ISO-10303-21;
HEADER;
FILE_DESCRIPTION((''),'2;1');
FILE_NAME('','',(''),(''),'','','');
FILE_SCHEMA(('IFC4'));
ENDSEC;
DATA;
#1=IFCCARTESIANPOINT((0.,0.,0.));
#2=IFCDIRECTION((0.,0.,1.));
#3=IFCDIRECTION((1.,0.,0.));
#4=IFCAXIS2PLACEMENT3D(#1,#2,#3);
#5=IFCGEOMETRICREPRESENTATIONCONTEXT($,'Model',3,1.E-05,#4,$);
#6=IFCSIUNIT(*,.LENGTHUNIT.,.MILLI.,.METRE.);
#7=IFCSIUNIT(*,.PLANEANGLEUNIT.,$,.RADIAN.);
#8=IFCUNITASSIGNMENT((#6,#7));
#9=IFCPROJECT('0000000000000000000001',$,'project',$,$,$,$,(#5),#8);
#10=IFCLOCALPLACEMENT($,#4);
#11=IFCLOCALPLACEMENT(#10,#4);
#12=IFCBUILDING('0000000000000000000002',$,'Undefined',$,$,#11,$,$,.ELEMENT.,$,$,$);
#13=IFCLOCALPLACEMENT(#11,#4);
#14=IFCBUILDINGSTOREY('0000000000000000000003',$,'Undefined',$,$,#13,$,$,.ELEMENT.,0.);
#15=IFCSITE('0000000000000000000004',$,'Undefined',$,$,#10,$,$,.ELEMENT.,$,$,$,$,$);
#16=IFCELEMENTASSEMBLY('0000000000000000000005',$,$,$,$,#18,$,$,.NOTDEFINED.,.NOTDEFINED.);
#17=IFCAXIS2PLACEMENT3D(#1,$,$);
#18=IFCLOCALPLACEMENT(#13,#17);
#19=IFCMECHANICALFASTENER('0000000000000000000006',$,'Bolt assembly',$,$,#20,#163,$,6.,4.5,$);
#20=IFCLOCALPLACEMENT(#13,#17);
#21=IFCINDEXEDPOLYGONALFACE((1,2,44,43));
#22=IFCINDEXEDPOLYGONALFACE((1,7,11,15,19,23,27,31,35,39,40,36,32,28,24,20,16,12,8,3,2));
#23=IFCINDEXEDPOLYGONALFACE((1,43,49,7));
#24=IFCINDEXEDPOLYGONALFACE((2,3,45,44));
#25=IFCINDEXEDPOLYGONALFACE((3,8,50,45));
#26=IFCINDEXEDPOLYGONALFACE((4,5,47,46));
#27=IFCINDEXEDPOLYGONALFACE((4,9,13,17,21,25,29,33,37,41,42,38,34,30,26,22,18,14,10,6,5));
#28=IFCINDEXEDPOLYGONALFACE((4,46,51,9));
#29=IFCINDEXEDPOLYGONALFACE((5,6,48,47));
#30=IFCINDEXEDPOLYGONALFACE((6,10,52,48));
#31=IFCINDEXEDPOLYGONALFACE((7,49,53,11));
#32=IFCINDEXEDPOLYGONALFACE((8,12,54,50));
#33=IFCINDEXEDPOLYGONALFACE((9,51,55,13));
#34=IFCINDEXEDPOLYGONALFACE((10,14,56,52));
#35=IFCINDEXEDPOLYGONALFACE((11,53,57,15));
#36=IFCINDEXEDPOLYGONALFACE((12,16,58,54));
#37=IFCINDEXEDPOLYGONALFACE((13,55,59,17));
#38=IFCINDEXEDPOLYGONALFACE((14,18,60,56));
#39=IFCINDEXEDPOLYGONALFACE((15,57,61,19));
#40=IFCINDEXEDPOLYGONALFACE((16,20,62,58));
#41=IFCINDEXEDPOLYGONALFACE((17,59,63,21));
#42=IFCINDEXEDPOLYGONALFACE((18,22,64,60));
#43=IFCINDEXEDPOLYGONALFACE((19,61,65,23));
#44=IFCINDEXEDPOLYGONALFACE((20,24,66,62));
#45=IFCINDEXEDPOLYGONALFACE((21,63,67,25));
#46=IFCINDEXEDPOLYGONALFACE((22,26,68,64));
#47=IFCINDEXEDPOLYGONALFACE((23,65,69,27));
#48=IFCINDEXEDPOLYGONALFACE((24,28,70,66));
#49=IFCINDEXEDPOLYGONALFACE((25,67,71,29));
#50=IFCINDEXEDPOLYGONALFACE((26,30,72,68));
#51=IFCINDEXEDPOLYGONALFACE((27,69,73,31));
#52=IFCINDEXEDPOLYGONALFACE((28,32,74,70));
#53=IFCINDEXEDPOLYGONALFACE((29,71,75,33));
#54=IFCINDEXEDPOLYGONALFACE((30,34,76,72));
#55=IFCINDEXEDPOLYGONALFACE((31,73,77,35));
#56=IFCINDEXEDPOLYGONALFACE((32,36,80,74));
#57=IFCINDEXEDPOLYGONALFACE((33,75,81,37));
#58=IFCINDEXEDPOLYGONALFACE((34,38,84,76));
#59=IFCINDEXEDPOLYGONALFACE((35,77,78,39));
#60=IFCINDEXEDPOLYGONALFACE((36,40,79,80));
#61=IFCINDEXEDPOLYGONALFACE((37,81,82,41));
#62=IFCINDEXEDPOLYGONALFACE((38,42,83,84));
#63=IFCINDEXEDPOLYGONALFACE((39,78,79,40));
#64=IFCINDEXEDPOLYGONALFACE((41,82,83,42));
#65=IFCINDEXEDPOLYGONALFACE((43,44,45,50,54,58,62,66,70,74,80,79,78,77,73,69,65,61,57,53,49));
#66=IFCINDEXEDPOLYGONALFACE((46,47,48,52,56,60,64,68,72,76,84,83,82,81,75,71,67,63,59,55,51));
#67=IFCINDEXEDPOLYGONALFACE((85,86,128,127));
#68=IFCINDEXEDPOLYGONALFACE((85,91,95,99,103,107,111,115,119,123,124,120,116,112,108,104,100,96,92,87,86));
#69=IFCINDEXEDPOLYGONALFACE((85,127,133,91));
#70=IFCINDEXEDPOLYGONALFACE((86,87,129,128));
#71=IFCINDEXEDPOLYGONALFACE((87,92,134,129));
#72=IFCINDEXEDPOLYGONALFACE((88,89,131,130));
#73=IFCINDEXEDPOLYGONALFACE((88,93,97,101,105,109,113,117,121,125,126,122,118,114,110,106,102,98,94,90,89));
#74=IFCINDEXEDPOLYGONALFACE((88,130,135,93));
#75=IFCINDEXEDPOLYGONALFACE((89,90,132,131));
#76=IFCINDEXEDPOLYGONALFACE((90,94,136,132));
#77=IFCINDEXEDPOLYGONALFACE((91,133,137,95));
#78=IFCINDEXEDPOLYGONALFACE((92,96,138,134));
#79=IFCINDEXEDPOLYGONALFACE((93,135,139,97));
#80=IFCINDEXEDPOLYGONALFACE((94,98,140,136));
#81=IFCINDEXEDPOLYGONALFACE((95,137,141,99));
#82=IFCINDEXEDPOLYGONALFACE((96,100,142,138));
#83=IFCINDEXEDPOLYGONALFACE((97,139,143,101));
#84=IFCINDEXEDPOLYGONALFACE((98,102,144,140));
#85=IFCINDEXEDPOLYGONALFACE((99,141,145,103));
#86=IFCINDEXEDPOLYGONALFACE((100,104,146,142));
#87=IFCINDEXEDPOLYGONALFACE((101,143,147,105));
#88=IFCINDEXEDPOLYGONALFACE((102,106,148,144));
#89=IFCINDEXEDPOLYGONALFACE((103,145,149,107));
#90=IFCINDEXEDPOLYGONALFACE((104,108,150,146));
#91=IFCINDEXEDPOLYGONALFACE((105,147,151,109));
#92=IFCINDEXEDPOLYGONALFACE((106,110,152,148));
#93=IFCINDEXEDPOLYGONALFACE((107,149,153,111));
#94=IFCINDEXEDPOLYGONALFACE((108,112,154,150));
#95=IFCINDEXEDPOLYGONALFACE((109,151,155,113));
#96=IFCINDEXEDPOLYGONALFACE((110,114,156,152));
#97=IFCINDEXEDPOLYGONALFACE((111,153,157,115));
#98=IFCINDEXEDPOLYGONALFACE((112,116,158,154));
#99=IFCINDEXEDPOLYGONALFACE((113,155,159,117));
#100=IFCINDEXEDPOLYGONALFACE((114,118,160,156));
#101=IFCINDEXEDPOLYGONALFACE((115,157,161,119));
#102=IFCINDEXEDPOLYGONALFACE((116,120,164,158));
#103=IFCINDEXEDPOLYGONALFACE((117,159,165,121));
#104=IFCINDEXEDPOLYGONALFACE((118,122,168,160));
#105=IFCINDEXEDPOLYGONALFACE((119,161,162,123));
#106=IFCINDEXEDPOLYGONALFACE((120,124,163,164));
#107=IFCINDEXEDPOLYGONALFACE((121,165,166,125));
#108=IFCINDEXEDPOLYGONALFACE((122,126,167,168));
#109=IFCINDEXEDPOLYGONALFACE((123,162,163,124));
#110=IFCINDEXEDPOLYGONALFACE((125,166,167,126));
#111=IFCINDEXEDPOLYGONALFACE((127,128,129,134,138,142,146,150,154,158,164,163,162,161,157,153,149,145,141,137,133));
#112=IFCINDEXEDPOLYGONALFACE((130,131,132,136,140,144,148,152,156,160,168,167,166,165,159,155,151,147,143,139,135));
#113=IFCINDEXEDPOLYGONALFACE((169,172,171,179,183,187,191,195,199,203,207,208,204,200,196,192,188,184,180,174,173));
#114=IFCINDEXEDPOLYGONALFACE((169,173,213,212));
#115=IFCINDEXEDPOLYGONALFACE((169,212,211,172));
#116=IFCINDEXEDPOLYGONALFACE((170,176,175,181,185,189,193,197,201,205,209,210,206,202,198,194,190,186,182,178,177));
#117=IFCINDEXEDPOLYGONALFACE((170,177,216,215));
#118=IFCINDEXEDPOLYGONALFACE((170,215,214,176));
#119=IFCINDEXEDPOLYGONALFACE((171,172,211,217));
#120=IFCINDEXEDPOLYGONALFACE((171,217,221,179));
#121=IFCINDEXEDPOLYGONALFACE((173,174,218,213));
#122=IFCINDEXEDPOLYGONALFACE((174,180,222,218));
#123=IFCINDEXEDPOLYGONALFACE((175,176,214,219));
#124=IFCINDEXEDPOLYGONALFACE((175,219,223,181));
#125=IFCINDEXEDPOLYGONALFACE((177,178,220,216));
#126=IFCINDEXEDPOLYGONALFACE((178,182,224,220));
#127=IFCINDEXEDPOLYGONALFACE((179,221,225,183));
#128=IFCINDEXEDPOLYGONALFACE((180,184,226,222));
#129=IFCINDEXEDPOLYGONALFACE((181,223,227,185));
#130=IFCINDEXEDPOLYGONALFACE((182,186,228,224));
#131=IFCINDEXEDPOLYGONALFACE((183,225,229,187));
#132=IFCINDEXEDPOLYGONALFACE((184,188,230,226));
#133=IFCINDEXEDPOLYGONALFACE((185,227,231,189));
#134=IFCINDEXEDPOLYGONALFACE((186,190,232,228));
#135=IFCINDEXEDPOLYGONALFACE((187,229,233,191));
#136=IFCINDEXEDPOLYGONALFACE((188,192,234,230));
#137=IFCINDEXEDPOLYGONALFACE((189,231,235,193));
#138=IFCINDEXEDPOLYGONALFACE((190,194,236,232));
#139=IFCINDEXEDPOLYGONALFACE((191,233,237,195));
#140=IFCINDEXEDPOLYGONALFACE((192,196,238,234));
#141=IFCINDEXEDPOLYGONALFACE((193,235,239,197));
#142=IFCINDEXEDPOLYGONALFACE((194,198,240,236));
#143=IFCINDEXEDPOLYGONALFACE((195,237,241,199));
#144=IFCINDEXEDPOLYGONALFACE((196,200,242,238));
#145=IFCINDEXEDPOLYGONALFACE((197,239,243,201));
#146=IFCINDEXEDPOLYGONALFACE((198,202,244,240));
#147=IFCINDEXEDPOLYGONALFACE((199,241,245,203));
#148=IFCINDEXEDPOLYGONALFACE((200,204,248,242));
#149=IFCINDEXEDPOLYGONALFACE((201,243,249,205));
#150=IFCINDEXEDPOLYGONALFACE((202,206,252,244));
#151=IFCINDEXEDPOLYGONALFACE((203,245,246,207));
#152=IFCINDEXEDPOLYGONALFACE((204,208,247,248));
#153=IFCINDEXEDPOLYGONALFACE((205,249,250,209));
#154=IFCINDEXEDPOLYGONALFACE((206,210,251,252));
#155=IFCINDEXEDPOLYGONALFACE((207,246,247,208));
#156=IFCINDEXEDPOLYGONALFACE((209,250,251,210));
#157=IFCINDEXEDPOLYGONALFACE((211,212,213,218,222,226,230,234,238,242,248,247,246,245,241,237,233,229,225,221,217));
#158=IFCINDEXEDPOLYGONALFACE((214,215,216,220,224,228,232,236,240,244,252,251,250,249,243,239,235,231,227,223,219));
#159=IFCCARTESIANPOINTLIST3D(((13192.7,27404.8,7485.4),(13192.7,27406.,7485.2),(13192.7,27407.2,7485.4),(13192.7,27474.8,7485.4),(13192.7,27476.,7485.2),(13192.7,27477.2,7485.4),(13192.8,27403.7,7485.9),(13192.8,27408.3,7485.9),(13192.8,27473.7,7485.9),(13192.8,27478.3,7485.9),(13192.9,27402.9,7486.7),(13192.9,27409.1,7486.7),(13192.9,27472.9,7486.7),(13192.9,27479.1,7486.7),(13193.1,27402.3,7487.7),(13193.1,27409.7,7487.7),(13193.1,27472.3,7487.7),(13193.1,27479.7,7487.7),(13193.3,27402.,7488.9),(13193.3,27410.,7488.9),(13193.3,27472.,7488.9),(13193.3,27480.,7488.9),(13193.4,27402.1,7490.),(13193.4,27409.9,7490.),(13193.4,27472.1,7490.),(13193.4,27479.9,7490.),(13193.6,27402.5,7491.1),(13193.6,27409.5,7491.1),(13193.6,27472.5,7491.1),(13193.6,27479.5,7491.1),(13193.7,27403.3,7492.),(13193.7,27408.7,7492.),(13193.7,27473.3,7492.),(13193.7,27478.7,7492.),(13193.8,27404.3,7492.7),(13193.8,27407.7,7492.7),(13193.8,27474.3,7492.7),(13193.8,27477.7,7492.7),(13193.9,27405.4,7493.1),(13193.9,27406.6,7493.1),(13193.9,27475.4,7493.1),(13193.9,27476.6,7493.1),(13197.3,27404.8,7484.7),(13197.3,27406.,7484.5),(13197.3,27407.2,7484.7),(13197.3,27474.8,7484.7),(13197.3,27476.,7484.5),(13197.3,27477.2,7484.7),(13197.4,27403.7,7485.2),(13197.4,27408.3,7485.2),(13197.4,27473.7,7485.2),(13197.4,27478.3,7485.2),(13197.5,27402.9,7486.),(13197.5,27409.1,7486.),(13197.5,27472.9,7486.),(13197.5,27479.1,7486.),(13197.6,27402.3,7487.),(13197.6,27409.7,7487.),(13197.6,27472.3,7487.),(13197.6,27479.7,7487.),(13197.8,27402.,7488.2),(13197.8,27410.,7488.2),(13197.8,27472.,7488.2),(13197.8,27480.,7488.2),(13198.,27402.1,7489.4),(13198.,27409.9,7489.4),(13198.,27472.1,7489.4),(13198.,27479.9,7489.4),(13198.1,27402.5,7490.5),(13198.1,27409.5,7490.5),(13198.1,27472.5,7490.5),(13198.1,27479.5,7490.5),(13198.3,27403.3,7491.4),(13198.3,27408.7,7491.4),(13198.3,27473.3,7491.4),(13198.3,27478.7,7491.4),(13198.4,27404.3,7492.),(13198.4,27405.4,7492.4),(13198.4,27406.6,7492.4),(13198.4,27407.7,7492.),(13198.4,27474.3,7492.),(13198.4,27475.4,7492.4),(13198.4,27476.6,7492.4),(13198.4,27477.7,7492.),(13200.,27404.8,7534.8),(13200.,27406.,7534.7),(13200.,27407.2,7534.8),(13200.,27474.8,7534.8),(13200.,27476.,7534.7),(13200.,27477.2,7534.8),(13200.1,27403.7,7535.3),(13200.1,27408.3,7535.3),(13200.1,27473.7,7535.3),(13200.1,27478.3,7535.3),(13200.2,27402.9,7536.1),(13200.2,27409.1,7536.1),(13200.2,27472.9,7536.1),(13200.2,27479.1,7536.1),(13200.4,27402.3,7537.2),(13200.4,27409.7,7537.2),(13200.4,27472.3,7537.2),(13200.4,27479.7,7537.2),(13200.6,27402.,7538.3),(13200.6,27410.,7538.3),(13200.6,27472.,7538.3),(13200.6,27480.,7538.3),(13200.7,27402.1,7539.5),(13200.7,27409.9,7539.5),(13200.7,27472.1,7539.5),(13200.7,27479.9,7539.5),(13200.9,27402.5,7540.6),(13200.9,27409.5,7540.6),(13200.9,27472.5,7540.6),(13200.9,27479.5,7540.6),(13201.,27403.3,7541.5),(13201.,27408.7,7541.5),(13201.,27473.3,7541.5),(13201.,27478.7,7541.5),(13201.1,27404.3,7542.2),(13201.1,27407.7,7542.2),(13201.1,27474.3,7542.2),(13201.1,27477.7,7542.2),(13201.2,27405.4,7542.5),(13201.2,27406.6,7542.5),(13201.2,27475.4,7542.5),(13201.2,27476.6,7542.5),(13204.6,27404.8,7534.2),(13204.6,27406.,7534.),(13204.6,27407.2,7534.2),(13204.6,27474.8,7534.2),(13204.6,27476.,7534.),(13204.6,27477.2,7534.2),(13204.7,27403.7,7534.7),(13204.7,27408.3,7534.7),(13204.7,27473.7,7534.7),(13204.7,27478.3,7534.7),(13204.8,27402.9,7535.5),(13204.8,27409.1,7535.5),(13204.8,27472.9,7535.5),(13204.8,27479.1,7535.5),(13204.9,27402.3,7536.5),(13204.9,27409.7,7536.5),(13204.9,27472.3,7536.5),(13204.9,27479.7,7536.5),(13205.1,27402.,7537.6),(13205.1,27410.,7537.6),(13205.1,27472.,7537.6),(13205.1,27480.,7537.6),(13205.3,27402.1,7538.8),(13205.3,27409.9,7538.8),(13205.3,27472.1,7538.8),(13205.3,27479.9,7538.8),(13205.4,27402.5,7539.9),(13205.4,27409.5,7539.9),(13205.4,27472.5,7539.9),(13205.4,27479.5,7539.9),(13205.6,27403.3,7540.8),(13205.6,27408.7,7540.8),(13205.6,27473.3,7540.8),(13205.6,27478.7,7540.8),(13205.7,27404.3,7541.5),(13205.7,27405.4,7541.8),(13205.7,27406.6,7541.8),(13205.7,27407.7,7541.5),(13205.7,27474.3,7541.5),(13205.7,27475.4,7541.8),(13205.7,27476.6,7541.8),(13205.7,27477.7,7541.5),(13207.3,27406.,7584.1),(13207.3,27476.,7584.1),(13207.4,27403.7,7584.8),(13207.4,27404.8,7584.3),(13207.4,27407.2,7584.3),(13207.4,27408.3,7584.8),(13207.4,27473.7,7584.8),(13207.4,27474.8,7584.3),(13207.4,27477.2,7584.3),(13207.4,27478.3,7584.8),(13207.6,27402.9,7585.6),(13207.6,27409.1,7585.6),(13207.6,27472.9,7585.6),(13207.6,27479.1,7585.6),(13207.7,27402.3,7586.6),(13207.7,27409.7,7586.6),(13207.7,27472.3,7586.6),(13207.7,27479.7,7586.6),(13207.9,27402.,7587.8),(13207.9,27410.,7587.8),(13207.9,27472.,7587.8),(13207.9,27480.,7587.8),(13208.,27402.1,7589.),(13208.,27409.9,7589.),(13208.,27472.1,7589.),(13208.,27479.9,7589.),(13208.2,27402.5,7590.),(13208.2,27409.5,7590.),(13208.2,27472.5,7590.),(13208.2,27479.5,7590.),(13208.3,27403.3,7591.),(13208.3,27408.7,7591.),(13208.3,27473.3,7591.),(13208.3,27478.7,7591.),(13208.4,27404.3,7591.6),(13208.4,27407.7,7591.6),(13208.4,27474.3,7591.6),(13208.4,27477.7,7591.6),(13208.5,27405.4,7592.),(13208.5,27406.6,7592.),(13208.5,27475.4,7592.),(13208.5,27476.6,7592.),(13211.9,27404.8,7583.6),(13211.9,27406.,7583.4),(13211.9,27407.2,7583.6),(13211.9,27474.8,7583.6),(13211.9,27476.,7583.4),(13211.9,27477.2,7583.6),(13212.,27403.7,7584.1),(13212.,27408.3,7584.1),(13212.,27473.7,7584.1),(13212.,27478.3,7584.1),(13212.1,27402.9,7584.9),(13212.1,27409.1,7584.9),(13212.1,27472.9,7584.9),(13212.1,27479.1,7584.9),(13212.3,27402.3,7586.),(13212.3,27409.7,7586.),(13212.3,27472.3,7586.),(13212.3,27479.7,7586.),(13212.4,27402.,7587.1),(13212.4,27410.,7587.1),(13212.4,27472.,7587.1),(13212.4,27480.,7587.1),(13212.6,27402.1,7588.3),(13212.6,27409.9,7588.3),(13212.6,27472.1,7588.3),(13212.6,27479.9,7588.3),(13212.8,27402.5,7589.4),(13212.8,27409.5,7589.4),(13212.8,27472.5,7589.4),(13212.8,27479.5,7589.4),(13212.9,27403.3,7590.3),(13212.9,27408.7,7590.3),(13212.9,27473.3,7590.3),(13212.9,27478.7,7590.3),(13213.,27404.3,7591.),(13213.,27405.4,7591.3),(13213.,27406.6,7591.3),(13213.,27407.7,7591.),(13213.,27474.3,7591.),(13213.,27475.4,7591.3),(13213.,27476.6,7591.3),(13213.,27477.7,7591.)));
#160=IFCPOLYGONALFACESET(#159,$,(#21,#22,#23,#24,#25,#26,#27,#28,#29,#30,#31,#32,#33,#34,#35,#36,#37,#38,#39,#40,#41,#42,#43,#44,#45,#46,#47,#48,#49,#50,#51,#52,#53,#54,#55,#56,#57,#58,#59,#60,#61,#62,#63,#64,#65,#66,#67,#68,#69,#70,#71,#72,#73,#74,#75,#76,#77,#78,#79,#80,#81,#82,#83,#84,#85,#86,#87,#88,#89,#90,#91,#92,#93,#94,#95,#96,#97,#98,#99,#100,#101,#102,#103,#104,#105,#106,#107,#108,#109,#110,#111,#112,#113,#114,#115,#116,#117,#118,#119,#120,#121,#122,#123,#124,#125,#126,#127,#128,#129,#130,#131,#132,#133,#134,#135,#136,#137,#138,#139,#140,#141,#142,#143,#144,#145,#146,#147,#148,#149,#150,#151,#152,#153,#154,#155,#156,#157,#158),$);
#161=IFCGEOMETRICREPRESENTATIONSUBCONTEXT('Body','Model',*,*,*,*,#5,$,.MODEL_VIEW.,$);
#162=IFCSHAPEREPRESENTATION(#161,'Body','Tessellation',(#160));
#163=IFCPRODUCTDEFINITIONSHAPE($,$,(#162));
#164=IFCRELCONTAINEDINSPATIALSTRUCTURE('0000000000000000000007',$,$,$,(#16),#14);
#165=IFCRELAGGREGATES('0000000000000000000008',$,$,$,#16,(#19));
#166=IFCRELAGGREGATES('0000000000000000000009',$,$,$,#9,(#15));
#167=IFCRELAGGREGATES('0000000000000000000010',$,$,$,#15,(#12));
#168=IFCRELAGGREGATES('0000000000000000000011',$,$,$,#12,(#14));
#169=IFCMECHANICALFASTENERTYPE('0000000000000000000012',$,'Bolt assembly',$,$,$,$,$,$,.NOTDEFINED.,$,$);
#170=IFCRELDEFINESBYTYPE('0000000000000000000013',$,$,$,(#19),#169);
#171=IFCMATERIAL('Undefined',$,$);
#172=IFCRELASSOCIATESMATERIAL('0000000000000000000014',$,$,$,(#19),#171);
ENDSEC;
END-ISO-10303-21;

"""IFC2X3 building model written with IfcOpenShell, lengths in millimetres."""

from ifc_helpers import new_model, si_unit, frame, origin_with_axes, origin_2d_with_axis, place, context, subcontext, project, spatial, circle, extrude, source, transform, mapped, material, type_object, element, aggregate, save


model = new_model("IFC2X3")

# Units and contexts
model_context = context("Model", 3, precision=1e-05, world=origin_with_axes())
body_context = subcontext(model_context, "Body", "Model", "MODEL_VIEW")
ifc_project = project(units=[si_unit("LENGTHUNIT", "METRE", prefix="MILLI"), si_unit("PLANEANGLEUNIT", "RADIAN")], contexts=[model_context])

# Site, building, storey
site_placement = place(None, origin_with_axes())
site = spatial("IfcSite", under=ifc_project, at=site_placement, Name="Undefined", CompositionType="ELEMENT")
building_placement = place(site_placement, origin_with_axes())
building = spatial("IfcBuilding", under=site, at=building_placement, Name="Undefined", CompositionType="ELEMENT")
storey_placement = place(building_placement, origin_with_axes())
storey = spatial("IfcBuildingStorey", under=building, at=storey_placement, Name="Undefined", CompositionType="ELEMENT", Elevation=0.0)

# Element assembly
assembly_1_placement = place(storey_placement, origin_with_axes())
assembly_1 = element("IfcElementAssembly", 1, at=assembly_1_placement, inside=storey, AssemblyPlace="NOTDEFINED", PredefinedType="NOTDEFINED")

# Mechanical fastener
ifc_material_1 = material(Name="Undefined")
mechanical_fastener_type = type_object("IfcMechanicalFastenerType", Name="Bolt assembly")
shared_shape_1 = source(origin_with_axes(), body_context, "Body", "SweptSolid", [
    extrude(circle(Radius=4.0, at=origin_2d_with_axis()), frame((0.0, 0.0, 0.0), z_axis=(0.0, 1.0, 0.0), x_axis=(1.0, 0.0, 0.0)), (0.0, 0.0, 1.0), 4.6),
])
mechanical_fastener_1_placement = place(assembly_1_placement, frame((13212.5, 27441.0, 7587.4), z_axis=(0.0, 1.0, 0.0), x_axis=(-0.146202, 0.0, -0.989255)))
mechanical_fastener_1 = element("IfcMechanicalFastener", 2, at=mechanical_fastener_1_placement, type_object=mechanical_fastener_type, material=ifc_material_1, Name="Bolt assembly", NominalDiameter=6.0, NominalLength=4.5, context=body_context, shape_type="MappedRepresentation", body=[
    mapped(shared_shape_1, transform((0.0, 0.0, 35.0))),
    mapped(shared_shape_1, transform((50.0, 0.0, 35.0))),
    mapped(shared_shape_1, transform((100.0, 0.0, 35.0))),
    mapped(shared_shape_1, transform((0.0, 0.0, -35.0))),
    mapped(shared_shape_1, transform((50.0, 0.0, -35.0))),
    mapped(shared_shape_1, transform((100.0, 0.0, -35.0))),
])

aggregate(assembly_1, [mechanical_fastener_1])

save(model, "model.ifc")
